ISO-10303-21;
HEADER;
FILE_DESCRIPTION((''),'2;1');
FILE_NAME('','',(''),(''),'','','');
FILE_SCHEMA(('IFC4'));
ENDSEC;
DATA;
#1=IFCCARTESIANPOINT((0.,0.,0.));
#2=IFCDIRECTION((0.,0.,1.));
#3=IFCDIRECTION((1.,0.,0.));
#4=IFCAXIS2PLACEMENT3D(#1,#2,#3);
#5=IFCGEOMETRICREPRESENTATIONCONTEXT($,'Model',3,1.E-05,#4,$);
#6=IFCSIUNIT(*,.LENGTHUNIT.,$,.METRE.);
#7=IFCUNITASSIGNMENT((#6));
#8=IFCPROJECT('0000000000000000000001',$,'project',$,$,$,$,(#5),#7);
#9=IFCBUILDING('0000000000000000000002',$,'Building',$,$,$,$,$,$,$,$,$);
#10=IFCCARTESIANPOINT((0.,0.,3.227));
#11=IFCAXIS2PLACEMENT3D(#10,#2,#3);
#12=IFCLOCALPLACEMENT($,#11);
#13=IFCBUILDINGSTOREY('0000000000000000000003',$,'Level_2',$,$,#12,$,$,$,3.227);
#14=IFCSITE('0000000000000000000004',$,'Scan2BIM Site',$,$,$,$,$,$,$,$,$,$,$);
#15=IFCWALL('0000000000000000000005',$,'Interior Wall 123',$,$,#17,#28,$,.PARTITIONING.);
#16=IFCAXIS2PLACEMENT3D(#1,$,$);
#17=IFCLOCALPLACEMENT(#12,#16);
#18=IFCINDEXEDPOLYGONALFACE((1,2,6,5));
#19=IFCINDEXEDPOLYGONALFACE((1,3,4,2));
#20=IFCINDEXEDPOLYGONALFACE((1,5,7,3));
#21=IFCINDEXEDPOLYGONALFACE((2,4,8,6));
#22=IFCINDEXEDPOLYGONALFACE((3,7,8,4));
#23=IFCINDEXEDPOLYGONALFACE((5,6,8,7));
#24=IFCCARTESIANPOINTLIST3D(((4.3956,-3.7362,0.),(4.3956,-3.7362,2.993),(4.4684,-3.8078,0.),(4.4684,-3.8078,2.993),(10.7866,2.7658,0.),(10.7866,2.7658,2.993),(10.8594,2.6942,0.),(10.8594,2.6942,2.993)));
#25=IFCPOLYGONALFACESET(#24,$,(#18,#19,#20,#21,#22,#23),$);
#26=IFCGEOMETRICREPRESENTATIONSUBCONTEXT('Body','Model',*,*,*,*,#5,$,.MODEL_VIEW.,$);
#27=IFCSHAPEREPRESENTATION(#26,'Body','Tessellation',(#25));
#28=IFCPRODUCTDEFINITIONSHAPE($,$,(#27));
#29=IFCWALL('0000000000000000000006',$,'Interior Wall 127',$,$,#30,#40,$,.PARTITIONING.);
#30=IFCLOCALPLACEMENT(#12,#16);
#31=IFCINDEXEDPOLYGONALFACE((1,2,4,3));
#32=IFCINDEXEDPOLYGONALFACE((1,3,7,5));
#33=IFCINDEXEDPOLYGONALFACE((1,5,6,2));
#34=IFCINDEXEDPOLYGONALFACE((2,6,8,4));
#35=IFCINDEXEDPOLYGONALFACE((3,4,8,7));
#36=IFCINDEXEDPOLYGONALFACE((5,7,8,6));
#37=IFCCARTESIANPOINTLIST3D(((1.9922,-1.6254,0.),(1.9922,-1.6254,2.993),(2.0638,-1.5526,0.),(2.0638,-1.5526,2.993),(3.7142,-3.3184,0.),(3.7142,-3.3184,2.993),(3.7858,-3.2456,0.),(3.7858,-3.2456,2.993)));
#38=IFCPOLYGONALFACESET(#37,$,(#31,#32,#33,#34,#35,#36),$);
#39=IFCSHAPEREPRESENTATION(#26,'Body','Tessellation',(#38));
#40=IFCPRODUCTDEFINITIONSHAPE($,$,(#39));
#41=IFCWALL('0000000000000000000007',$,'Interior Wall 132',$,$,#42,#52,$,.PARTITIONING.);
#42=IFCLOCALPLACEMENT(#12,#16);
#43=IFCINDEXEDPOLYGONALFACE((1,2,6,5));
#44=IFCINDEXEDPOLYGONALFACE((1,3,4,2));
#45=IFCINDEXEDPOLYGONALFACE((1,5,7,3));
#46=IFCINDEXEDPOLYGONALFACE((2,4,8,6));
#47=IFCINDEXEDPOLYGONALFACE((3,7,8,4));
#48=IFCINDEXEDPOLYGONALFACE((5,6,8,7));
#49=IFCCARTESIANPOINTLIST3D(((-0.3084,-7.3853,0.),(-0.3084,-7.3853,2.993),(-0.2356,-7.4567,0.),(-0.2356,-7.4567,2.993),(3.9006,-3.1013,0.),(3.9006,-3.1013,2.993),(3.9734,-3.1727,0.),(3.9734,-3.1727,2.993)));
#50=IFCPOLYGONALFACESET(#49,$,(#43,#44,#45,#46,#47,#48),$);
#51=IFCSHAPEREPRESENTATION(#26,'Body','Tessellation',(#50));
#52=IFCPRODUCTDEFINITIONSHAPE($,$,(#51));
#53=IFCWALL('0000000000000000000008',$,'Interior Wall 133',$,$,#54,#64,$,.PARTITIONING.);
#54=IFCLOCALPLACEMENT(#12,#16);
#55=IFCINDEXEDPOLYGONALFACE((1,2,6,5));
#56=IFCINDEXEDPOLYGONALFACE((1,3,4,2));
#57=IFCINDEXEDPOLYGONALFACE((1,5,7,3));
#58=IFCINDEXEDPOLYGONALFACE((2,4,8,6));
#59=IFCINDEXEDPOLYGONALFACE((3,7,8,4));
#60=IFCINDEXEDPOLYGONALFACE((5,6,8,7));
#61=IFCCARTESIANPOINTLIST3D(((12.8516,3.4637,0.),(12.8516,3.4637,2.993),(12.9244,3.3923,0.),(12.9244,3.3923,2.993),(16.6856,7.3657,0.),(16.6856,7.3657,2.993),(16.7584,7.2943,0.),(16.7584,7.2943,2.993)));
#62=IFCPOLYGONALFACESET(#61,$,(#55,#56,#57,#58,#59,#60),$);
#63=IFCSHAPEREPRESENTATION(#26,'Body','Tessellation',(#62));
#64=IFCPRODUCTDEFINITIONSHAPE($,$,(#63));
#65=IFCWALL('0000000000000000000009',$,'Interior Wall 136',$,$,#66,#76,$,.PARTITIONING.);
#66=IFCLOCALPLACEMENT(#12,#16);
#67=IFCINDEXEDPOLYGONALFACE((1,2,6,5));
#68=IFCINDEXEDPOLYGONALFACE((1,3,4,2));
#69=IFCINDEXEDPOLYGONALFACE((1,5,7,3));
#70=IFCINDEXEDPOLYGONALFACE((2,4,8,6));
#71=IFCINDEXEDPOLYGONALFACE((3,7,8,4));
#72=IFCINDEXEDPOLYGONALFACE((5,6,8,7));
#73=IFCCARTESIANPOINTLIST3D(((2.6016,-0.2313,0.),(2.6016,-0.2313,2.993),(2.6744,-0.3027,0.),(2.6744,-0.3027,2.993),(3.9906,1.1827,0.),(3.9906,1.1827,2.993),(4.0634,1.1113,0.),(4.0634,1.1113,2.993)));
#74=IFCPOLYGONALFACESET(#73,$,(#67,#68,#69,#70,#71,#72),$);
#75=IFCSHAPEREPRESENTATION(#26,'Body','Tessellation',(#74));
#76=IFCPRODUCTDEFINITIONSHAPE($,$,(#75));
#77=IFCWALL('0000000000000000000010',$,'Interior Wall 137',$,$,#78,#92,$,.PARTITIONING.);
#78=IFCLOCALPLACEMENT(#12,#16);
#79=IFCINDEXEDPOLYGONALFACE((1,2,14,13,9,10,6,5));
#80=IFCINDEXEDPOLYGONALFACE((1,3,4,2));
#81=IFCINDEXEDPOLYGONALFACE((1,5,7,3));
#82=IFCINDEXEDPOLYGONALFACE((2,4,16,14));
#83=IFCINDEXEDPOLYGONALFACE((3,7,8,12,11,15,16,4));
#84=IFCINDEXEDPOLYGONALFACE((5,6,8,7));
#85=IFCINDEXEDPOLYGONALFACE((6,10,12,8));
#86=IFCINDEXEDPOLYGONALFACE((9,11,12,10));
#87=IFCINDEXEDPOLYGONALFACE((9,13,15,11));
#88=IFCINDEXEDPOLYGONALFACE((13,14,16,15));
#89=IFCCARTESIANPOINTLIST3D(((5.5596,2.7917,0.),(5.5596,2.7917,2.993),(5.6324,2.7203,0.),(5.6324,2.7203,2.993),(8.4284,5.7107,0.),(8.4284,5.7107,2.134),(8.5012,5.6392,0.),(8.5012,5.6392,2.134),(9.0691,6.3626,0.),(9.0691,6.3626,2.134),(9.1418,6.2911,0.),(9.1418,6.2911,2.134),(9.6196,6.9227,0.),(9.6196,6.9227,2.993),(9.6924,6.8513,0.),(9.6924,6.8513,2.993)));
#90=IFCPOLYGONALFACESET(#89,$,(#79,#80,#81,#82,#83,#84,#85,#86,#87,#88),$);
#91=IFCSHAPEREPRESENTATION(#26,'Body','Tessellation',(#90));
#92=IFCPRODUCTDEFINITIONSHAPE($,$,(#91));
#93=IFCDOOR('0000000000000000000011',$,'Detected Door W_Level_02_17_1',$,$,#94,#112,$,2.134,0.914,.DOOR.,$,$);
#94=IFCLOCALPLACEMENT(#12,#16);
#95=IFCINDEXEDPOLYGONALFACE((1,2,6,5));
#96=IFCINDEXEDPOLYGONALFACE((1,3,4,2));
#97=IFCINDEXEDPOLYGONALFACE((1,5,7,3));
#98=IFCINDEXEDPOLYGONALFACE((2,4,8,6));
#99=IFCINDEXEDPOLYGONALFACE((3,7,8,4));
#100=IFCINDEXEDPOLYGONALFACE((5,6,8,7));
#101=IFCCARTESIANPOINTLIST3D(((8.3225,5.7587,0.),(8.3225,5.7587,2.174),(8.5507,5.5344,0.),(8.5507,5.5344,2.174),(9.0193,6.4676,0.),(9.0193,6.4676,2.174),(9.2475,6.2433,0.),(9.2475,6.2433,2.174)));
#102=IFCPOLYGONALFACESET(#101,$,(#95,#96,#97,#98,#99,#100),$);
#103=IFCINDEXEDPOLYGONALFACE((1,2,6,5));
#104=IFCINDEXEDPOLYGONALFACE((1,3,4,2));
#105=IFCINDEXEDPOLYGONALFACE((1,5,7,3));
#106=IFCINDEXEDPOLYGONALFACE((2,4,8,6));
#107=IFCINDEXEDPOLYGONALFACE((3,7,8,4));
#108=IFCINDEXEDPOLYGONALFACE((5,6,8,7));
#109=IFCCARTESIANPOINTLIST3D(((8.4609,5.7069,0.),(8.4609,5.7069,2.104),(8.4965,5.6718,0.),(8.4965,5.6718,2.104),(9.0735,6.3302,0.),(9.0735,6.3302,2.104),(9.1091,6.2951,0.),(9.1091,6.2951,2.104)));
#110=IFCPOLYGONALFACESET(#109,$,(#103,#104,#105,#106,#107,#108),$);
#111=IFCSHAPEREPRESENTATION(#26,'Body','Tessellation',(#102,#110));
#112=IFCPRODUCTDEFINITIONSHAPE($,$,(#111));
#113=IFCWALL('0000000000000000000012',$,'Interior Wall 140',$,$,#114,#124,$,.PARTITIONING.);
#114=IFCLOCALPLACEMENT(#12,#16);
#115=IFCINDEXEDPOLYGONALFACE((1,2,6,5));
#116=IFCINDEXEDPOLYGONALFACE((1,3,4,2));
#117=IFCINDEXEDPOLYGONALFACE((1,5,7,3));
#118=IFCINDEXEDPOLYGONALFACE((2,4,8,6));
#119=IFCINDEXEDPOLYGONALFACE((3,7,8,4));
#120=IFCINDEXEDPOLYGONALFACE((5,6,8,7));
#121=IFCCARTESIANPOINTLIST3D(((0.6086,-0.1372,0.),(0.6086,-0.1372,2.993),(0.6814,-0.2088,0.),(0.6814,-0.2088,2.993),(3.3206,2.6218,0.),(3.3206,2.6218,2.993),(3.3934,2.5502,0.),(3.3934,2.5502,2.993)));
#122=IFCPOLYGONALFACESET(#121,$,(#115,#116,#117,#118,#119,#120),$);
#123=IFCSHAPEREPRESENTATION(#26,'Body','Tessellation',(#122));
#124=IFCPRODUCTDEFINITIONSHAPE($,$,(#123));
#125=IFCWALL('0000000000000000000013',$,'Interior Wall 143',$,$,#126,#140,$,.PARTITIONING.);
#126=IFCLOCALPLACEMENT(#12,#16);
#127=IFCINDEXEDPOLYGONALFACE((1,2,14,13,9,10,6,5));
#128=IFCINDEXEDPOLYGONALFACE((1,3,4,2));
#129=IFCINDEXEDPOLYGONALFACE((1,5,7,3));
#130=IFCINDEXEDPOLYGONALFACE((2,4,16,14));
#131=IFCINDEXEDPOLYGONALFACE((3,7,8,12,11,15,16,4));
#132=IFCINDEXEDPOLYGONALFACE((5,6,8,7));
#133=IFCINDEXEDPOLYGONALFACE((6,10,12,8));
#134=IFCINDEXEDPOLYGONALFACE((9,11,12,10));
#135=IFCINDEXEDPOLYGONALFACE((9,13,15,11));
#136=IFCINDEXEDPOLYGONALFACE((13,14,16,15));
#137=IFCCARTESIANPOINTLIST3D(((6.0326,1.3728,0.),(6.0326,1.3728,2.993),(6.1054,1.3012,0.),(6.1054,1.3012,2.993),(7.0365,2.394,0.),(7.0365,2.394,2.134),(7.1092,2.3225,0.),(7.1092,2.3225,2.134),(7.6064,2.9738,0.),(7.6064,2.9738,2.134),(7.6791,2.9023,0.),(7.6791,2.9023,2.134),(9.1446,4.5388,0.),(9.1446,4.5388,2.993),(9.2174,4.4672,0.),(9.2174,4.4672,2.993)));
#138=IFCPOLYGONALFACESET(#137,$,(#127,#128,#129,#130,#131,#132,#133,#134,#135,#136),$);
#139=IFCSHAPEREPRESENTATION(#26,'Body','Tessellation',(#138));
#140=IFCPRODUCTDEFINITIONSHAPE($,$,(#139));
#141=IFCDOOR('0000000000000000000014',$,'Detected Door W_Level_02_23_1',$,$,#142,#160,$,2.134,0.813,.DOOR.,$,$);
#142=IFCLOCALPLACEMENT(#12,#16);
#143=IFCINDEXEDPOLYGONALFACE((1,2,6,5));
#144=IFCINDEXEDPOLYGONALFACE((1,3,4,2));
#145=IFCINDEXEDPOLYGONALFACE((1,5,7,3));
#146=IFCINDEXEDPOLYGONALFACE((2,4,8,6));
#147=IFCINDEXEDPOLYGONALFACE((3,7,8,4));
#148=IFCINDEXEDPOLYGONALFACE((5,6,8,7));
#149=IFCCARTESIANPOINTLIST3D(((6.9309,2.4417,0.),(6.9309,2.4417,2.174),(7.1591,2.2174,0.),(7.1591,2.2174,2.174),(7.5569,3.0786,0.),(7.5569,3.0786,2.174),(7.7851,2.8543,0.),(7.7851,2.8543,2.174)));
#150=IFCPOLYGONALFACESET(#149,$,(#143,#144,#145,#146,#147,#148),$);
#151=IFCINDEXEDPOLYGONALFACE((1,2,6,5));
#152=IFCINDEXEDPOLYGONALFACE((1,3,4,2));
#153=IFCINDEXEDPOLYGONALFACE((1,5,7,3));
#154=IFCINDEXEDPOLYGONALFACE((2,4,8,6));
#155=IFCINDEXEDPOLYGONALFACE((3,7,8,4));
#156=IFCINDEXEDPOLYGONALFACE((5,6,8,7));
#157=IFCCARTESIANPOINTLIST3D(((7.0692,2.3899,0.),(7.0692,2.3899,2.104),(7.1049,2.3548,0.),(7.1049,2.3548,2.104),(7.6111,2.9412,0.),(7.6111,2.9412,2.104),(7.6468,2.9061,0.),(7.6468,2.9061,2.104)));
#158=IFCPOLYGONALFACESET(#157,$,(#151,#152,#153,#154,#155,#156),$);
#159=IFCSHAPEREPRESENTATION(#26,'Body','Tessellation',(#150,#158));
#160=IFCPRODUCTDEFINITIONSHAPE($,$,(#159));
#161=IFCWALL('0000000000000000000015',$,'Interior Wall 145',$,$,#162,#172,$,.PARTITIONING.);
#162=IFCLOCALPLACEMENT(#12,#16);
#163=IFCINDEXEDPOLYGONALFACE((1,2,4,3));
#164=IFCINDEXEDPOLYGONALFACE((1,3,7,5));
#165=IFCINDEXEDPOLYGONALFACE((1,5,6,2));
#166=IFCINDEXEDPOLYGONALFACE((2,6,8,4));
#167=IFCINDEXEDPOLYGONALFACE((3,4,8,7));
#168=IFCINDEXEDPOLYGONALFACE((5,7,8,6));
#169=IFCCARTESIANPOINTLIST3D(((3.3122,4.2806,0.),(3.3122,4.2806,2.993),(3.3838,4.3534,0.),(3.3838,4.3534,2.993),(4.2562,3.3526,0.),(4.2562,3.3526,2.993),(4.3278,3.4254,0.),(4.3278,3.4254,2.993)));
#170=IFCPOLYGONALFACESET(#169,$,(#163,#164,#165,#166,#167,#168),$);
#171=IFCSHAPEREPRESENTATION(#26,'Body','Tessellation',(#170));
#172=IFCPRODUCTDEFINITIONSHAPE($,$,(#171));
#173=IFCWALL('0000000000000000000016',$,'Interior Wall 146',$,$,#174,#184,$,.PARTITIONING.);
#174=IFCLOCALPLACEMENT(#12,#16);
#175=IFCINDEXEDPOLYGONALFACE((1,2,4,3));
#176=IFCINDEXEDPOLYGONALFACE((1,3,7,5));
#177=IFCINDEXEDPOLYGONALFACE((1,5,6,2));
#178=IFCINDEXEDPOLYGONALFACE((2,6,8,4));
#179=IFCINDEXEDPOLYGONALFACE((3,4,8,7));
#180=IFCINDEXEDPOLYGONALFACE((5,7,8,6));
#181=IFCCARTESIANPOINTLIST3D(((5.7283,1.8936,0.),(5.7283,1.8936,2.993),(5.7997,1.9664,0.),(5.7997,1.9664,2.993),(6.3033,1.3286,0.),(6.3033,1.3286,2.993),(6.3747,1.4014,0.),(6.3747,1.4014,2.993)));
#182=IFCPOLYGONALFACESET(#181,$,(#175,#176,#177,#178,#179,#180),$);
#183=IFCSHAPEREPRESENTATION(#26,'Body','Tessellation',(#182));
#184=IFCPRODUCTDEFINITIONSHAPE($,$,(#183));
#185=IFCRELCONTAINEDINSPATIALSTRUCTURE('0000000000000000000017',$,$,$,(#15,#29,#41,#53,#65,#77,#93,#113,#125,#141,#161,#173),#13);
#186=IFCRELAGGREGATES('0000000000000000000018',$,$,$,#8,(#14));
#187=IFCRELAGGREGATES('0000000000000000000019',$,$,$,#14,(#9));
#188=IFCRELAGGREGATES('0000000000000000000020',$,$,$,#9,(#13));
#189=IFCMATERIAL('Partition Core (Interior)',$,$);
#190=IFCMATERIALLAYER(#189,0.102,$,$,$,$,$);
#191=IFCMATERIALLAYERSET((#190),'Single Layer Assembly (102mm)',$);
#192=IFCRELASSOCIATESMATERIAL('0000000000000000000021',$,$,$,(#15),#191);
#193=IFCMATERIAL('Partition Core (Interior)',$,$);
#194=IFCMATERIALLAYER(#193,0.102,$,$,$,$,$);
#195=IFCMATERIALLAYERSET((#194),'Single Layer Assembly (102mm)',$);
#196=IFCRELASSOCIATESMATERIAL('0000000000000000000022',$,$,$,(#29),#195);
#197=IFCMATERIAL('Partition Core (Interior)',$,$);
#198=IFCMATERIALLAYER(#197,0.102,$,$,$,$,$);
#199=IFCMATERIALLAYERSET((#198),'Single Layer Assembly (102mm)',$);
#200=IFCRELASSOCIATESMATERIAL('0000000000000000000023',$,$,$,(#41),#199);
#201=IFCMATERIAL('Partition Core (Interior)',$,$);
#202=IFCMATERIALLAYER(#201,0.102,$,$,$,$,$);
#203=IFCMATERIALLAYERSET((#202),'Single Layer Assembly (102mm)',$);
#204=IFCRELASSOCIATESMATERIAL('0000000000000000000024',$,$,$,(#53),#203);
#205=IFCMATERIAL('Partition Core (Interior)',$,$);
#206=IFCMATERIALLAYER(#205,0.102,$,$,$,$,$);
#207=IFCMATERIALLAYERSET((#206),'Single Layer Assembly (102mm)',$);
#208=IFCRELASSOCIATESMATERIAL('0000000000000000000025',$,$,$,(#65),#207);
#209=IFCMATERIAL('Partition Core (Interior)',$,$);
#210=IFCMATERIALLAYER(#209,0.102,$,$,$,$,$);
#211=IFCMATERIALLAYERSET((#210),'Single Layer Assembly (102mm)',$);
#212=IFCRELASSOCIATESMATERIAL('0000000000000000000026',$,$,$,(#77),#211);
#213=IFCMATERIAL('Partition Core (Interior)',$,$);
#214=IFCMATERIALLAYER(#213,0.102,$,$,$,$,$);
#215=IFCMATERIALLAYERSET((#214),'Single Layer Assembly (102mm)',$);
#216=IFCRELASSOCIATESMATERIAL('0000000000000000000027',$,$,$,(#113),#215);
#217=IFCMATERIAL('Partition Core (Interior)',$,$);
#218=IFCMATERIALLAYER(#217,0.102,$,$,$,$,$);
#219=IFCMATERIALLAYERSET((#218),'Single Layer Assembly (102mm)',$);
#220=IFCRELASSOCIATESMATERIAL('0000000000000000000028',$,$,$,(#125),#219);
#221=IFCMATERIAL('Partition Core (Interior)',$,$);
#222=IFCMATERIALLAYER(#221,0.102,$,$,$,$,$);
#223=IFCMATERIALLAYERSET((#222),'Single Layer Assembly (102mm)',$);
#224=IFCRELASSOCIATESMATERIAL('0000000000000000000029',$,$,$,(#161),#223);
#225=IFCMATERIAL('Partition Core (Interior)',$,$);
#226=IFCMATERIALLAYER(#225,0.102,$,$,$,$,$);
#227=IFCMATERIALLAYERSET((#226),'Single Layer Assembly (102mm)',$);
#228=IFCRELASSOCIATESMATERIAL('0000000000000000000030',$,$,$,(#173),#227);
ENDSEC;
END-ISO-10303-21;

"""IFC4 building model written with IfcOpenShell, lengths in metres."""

from ifc_helpers import new_model, si_unit, frame, origin, origin_with_axes, place, context, subcontext, project, spatial, rectangle, extrude, material, layer, layer_set, element, fill, save


model = new_model("IFC4")

# Units and contexts
model_context = context("Model", 3, precision=1e-05, world=origin_with_axes())
body_context = subcontext(model_context, "Body", "Model", "MODEL_VIEW")
ifc_project = project(units=[si_unit("LENGTHUNIT", "METRE")], contexts=[model_context])

# Site, building, storey
site = spatial("IfcSite", under=ifc_project, Name="Scan2BIM Site")
building = spatial("IfcBuilding", under=site, Name="Building")
storey_placement = place(None, frame((0.0, 0.0, 3.227), z_axis=(0.0, 0.0, 1.0), x_axis=(1.0, 0.0, 0.0)))
storey = spatial("IfcBuildingStorey", under=building, at=storey_placement, Name="Level_2", Elevation=3.227)

# Walls
ifc_material_1 = material(Name="Partition Core (Interior)")
ifc_layer_1 = layer(ifc_material_1, 0.102)
ifc_layer_set_1 = layer_set([ifc_layer_1], Name="Single Layer Assembly (102mm)")
wall_1_placement = place(storey_placement, frame((7.6275, -0.521, 0.0), z_axis=(0.0, 0.0, 1.0), x_axis=(-0.700993, -0.713168, 0.0)))
element("IfcWall", 1, at=wall_1_placement, inside=storey, material=ifc_layer_set_1, Name="Interior Wall 123", PredefinedType="PARTITIONING", context=body_context, shape_type="SweptSolid", body=[
    extrude(rectangle(XDim=9.1171, YDim=0.102), origin(), (0.0, 0.0, 1.0), 2.993),
])
ifc_material_2 = material(Name="Partition Core (Interior)")
ifc_layer_2 = layer(ifc_material_2, 0.102)
ifc_layer_set_2 = layer_set([ifc_layer_2], Name="Single Layer Assembly (102mm)")
wall_2_placement = place(storey_placement, frame((2.889, -2.4355, 0.0), z_axis=(0.0, 0.0, 1.0), x_axis=(-0.713086, 0.701077, 0.0)))
element("IfcWall", 2, at=wall_2_placement, inside=storey, material=ifc_layer_set_2, Name="Interior Wall 127", PredefinedType="PARTITIONING", context=body_context, shape_type="SweptSolid", body=[
    extrude(rectangle(XDim=2.4149, YDim=0.102), origin(), (0.0, 0.0, 1.0), 2.993),
])
ifc_material_3 = material(Name="Partition Core (Interior)")
ifc_layer_3 = layer(ifc_material_3, 0.102)
ifc_layer_set_3 = layer_set([ifc_layer_3], Name="Single Layer Assembly (102mm)")
wall_3_placement = place(storey_placement, frame((1.8325, -5.279, 0.0), z_axis=(0.0, 0.0, 1.0), x_axis=(0.700835, 0.713323, 0.0)))
element("IfcWall", 3, at=wall_3_placement, inside=storey, material=ifc_layer_set_3, Name="Interior Wall 132", PredefinedType="PARTITIONING", context=body_context, shape_type="SweptSolid", body=[
    extrude(rectangle(XDim=6.0057, YDim=0.102), origin(), (0.0, 0.0, 1.0), 2.993),
])
ifc_material_4 = material(Name="Partition Core (Interior)")
ifc_layer_4 = layer(ifc_material_4, 0.102)
ifc_layer_set_4 = layer_set([ifc_layer_4], Name="Single Layer Assembly (102mm)")
wall_4_placement = place(storey_placement, frame((14.805, 5.379, 0.0), z_axis=(0.0, 0.0, 1.0), x_axis=(0.700864, 0.713295, 0.0)))
element("IfcWall", 4, at=wall_4_placement, inside=storey, material=ifc_layer_set_4, Name="Interior Wall 133", PredefinedType="PARTITIONING", context=body_context, shape_type="SweptSolid", body=[
    extrude(rectangle(XDim=5.4704, YDim=0.102), origin(), (0.0, 0.0, 1.0), 2.993),
])
ifc_material_5 = material(Name="Partition Core (Interior)")
ifc_layer_5 = layer(ifc_material_5, 0.102)
ifc_layer_set_5 = layer_set([ifc_layer_5], Name="Single Layer Assembly (102mm)")
wall_5_placement = place(storey_placement, frame((3.3325, 0.44, 0.0), z_axis=(0.0, 0.0, 1.0), x_axis=(0.700772, 0.713385, 0.0)))
element("IfcWall", 5, at=wall_5_placement, inside=storey, material=ifc_layer_set_5, Name="Interior Wall 136", PredefinedType="PARTITIONING", context=body_context, shape_type="SweptSolid", body=[
    extrude(rectangle(XDim=1.9821, YDim=0.102), origin(), (0.0, 0.0, 1.0), 2.993),
])

# Wall, opening, door
ifc_material_6 = material(Name="Partition Core (Interior)")
ifc_layer_6 = layer(ifc_material_6, 0.102)
ifc_layer_set_6 = layer_set([ifc_layer_6], Name="Single Layer Assembly (102mm)")
wall_6_placement = place(storey_placement, frame((7.626, 4.8215, 0.0), z_axis=(0.0, 0.0, 1.0), x_axis=(0.700951, 0.713209, 0.0)))
wall_6 = element("IfcWall", 6, at=wall_6_placement, inside=storey, material=ifc_layer_set_6, Name="Interior Wall 137", PredefinedType="PARTITIONING", context=body_context, shape_type="SweptSolid", body=[
    extrude(rectangle(XDim=5.7921, YDim=0.102), origin(), (0.0, 0.0, 1.0), 2.993),
])
opening_1_placement = place(None, frame((8.785, 6.001, 3.227), z_axis=(0.0, 0.0, 1.0), x_axis=(0.700951, 0.713209, 0.0)))
opening_1 = element("IfcOpeningElement", 7, at=opening_1_placement, cuts=wall_6, PredefinedType="OPENING", context=body_context, shape_type="SweptSolid", body=[
    extrude(rectangle(XDim=0.914, YDim=0.202), origin(), (0.0, 0.0, 1.0), 2.134),
])
door_1_placement = place(opening_1_placement, frame((0.0, 0.0, 0.0), z_axis=(0.0, 0.0, 1.0), x_axis=(1.0, 0.0, 0.0)))
door_1 = element("IfcDoor", 8, at=door_1_placement, inside=storey, Name="Detected Door W_Level_02_17_1", OverallHeight=2.134, OverallWidth=0.914, PredefinedType="DOOR", context=body_context, shape_type="SweptSolid", body=[
    extrude(rectangle(XDim=0.994, YDim=0.32), origin(), (0.0, 0.0, 1.0), 2.174),
    extrude(rectangle(XDim=0.874, YDim=0.05), origin(), (0.0, 0.0, 1.0), 2.104),
])
fill(opening_1, door_1)

# Wall
ifc_material_7 = material(Name="Partition Core (Interior)")
ifc_layer_7 = layer(ifc_material_7, 0.102)
ifc_layer_set_7 = layer_set([ifc_layer_7], Name="Single Layer Assembly (102mm)")
wall_7_placement = place(storey_placement, frame((2.001, 1.2065, 0.0), z_axis=(0.0, 0.0, 1.0), x_axis=(-0.701006, -0.713155, 0.0)))
element("IfcWall", 9, at=wall_7_placement, inside=storey, material=ifc_layer_set_7, Name="Interior Wall 140", PredefinedType="PARTITIONING", context=body_context, shape_type="SweptSolid", body=[
    extrude(rectangle(XDim=3.8687, YDim=0.102), origin(), (0.0, 0.0, 1.0), 2.993),
])

# Wall, opening, door
ifc_material_8 = material(Name="Partition Core (Interior)")
ifc_layer_8 = layer(ifc_material_8, 0.102)
ifc_layer_set_8 = layer_set([ifc_layer_8], Name="Single Layer Assembly (102mm)")
wall_8_placement = place(storey_placement, frame((7.625, 2.92, 0.0), z_axis=(0.0, 0.0, 1.0), x_axis=(-0.700999, -0.713163, 0.0)))
wall_8 = element("IfcWall", 10, at=wall_8_placement, inside=storey, material=ifc_layer_set_8, Name="Interior Wall 143", PredefinedType="PARTITIONING", context=body_context, shape_type="SweptSolid", body=[
    extrude(rectangle(XDim=4.4394, YDim=0.102), origin(), (0.0, 0.0, 1.0), 2.993),
])
opening_2_placement = place(None, frame((7.358, 2.648, 3.227), z_axis=(0.0, 0.0, 1.0), x_axis=(-0.700999, -0.713163, 0.0)))
opening_2 = element("IfcOpeningElement", 11, at=opening_2_placement, cuts=wall_8, PredefinedType="OPENING", context=body_context, shape_type="SweptSolid", body=[
    extrude(rectangle(XDim=0.813, YDim=0.202), origin(), (0.0, 0.0, 1.0), 2.134),
])
door_2_placement = place(opening_2_placement, frame((0.0, 0.0, 0.0), z_axis=(0.0, 0.0, 1.0), x_axis=(1.0, 0.0, 0.0)))
door_2 = element("IfcDoor", 12, at=door_2_placement, inside=storey, Name="Detected Door W_Level_02_23_1", OverallHeight=2.134, OverallWidth=0.813, PredefinedType="DOOR", context=body_context, shape_type="SweptSolid", body=[
    extrude(rectangle(XDim=0.893, YDim=0.32), origin(), (0.0, 0.0, 1.0), 2.174),
    extrude(rectangle(XDim=0.773, YDim=0.05), origin(), (0.0, 0.0, 1.0), 2.104),
])
fill(opening_2, door_2)

# Walls
ifc_material_9 = material(Name="Partition Core (Interior)")
ifc_layer_9 = layer(ifc_material_9, 0.102)
ifc_layer_set_9 = layer_set([ifc_layer_9], Name="Single Layer Assembly (102mm)")
wall_9_placement = place(storey_placement, frame((3.82, 3.853, 0.0), z_axis=(0.0, 0.0, 1.0), x_axis=(0.713124, -0.701038, 0.0)))
element("IfcWall", 13, at=wall_9_placement, inside=storey, material=ifc_layer_set_9, Name="Interior Wall 145", PredefinedType="PARTITIONING", context=body_context, shape_type="SweptSolid", body=[
    extrude(rectangle(XDim=1.3238, YDim=0.102), origin(), (0.0, 0.0, 1.0), 2.993),
])
ifc_material_10 = material(Name="Partition Core (Interior)")
ifc_layer_10 = layer(ifc_material_10, 0.102)
ifc_layer_set_10 = layer_set([ifc_layer_10], Name="Single Layer Assembly (102mm)")
wall_10_placement = place(storey_placement, frame((6.0515, 1.6475, 0.0), z_axis=(0.0, 0.0, 1.0), x_axis=(0.713282, -0.700877, 0.0)))
element("IfcWall", 14, at=wall_10_placement, inside=storey, material=ifc_layer_set_10, Name="Interior Wall 146", PredefinedType="PARTITIONING", context=body_context, shape_type="SweptSolid", body=[
    extrude(rectangle(XDim=0.8061, YDim=0.102), origin(), (0.0, 0.0, 1.0), 2.993),
])

save(model, "model.ifc")
